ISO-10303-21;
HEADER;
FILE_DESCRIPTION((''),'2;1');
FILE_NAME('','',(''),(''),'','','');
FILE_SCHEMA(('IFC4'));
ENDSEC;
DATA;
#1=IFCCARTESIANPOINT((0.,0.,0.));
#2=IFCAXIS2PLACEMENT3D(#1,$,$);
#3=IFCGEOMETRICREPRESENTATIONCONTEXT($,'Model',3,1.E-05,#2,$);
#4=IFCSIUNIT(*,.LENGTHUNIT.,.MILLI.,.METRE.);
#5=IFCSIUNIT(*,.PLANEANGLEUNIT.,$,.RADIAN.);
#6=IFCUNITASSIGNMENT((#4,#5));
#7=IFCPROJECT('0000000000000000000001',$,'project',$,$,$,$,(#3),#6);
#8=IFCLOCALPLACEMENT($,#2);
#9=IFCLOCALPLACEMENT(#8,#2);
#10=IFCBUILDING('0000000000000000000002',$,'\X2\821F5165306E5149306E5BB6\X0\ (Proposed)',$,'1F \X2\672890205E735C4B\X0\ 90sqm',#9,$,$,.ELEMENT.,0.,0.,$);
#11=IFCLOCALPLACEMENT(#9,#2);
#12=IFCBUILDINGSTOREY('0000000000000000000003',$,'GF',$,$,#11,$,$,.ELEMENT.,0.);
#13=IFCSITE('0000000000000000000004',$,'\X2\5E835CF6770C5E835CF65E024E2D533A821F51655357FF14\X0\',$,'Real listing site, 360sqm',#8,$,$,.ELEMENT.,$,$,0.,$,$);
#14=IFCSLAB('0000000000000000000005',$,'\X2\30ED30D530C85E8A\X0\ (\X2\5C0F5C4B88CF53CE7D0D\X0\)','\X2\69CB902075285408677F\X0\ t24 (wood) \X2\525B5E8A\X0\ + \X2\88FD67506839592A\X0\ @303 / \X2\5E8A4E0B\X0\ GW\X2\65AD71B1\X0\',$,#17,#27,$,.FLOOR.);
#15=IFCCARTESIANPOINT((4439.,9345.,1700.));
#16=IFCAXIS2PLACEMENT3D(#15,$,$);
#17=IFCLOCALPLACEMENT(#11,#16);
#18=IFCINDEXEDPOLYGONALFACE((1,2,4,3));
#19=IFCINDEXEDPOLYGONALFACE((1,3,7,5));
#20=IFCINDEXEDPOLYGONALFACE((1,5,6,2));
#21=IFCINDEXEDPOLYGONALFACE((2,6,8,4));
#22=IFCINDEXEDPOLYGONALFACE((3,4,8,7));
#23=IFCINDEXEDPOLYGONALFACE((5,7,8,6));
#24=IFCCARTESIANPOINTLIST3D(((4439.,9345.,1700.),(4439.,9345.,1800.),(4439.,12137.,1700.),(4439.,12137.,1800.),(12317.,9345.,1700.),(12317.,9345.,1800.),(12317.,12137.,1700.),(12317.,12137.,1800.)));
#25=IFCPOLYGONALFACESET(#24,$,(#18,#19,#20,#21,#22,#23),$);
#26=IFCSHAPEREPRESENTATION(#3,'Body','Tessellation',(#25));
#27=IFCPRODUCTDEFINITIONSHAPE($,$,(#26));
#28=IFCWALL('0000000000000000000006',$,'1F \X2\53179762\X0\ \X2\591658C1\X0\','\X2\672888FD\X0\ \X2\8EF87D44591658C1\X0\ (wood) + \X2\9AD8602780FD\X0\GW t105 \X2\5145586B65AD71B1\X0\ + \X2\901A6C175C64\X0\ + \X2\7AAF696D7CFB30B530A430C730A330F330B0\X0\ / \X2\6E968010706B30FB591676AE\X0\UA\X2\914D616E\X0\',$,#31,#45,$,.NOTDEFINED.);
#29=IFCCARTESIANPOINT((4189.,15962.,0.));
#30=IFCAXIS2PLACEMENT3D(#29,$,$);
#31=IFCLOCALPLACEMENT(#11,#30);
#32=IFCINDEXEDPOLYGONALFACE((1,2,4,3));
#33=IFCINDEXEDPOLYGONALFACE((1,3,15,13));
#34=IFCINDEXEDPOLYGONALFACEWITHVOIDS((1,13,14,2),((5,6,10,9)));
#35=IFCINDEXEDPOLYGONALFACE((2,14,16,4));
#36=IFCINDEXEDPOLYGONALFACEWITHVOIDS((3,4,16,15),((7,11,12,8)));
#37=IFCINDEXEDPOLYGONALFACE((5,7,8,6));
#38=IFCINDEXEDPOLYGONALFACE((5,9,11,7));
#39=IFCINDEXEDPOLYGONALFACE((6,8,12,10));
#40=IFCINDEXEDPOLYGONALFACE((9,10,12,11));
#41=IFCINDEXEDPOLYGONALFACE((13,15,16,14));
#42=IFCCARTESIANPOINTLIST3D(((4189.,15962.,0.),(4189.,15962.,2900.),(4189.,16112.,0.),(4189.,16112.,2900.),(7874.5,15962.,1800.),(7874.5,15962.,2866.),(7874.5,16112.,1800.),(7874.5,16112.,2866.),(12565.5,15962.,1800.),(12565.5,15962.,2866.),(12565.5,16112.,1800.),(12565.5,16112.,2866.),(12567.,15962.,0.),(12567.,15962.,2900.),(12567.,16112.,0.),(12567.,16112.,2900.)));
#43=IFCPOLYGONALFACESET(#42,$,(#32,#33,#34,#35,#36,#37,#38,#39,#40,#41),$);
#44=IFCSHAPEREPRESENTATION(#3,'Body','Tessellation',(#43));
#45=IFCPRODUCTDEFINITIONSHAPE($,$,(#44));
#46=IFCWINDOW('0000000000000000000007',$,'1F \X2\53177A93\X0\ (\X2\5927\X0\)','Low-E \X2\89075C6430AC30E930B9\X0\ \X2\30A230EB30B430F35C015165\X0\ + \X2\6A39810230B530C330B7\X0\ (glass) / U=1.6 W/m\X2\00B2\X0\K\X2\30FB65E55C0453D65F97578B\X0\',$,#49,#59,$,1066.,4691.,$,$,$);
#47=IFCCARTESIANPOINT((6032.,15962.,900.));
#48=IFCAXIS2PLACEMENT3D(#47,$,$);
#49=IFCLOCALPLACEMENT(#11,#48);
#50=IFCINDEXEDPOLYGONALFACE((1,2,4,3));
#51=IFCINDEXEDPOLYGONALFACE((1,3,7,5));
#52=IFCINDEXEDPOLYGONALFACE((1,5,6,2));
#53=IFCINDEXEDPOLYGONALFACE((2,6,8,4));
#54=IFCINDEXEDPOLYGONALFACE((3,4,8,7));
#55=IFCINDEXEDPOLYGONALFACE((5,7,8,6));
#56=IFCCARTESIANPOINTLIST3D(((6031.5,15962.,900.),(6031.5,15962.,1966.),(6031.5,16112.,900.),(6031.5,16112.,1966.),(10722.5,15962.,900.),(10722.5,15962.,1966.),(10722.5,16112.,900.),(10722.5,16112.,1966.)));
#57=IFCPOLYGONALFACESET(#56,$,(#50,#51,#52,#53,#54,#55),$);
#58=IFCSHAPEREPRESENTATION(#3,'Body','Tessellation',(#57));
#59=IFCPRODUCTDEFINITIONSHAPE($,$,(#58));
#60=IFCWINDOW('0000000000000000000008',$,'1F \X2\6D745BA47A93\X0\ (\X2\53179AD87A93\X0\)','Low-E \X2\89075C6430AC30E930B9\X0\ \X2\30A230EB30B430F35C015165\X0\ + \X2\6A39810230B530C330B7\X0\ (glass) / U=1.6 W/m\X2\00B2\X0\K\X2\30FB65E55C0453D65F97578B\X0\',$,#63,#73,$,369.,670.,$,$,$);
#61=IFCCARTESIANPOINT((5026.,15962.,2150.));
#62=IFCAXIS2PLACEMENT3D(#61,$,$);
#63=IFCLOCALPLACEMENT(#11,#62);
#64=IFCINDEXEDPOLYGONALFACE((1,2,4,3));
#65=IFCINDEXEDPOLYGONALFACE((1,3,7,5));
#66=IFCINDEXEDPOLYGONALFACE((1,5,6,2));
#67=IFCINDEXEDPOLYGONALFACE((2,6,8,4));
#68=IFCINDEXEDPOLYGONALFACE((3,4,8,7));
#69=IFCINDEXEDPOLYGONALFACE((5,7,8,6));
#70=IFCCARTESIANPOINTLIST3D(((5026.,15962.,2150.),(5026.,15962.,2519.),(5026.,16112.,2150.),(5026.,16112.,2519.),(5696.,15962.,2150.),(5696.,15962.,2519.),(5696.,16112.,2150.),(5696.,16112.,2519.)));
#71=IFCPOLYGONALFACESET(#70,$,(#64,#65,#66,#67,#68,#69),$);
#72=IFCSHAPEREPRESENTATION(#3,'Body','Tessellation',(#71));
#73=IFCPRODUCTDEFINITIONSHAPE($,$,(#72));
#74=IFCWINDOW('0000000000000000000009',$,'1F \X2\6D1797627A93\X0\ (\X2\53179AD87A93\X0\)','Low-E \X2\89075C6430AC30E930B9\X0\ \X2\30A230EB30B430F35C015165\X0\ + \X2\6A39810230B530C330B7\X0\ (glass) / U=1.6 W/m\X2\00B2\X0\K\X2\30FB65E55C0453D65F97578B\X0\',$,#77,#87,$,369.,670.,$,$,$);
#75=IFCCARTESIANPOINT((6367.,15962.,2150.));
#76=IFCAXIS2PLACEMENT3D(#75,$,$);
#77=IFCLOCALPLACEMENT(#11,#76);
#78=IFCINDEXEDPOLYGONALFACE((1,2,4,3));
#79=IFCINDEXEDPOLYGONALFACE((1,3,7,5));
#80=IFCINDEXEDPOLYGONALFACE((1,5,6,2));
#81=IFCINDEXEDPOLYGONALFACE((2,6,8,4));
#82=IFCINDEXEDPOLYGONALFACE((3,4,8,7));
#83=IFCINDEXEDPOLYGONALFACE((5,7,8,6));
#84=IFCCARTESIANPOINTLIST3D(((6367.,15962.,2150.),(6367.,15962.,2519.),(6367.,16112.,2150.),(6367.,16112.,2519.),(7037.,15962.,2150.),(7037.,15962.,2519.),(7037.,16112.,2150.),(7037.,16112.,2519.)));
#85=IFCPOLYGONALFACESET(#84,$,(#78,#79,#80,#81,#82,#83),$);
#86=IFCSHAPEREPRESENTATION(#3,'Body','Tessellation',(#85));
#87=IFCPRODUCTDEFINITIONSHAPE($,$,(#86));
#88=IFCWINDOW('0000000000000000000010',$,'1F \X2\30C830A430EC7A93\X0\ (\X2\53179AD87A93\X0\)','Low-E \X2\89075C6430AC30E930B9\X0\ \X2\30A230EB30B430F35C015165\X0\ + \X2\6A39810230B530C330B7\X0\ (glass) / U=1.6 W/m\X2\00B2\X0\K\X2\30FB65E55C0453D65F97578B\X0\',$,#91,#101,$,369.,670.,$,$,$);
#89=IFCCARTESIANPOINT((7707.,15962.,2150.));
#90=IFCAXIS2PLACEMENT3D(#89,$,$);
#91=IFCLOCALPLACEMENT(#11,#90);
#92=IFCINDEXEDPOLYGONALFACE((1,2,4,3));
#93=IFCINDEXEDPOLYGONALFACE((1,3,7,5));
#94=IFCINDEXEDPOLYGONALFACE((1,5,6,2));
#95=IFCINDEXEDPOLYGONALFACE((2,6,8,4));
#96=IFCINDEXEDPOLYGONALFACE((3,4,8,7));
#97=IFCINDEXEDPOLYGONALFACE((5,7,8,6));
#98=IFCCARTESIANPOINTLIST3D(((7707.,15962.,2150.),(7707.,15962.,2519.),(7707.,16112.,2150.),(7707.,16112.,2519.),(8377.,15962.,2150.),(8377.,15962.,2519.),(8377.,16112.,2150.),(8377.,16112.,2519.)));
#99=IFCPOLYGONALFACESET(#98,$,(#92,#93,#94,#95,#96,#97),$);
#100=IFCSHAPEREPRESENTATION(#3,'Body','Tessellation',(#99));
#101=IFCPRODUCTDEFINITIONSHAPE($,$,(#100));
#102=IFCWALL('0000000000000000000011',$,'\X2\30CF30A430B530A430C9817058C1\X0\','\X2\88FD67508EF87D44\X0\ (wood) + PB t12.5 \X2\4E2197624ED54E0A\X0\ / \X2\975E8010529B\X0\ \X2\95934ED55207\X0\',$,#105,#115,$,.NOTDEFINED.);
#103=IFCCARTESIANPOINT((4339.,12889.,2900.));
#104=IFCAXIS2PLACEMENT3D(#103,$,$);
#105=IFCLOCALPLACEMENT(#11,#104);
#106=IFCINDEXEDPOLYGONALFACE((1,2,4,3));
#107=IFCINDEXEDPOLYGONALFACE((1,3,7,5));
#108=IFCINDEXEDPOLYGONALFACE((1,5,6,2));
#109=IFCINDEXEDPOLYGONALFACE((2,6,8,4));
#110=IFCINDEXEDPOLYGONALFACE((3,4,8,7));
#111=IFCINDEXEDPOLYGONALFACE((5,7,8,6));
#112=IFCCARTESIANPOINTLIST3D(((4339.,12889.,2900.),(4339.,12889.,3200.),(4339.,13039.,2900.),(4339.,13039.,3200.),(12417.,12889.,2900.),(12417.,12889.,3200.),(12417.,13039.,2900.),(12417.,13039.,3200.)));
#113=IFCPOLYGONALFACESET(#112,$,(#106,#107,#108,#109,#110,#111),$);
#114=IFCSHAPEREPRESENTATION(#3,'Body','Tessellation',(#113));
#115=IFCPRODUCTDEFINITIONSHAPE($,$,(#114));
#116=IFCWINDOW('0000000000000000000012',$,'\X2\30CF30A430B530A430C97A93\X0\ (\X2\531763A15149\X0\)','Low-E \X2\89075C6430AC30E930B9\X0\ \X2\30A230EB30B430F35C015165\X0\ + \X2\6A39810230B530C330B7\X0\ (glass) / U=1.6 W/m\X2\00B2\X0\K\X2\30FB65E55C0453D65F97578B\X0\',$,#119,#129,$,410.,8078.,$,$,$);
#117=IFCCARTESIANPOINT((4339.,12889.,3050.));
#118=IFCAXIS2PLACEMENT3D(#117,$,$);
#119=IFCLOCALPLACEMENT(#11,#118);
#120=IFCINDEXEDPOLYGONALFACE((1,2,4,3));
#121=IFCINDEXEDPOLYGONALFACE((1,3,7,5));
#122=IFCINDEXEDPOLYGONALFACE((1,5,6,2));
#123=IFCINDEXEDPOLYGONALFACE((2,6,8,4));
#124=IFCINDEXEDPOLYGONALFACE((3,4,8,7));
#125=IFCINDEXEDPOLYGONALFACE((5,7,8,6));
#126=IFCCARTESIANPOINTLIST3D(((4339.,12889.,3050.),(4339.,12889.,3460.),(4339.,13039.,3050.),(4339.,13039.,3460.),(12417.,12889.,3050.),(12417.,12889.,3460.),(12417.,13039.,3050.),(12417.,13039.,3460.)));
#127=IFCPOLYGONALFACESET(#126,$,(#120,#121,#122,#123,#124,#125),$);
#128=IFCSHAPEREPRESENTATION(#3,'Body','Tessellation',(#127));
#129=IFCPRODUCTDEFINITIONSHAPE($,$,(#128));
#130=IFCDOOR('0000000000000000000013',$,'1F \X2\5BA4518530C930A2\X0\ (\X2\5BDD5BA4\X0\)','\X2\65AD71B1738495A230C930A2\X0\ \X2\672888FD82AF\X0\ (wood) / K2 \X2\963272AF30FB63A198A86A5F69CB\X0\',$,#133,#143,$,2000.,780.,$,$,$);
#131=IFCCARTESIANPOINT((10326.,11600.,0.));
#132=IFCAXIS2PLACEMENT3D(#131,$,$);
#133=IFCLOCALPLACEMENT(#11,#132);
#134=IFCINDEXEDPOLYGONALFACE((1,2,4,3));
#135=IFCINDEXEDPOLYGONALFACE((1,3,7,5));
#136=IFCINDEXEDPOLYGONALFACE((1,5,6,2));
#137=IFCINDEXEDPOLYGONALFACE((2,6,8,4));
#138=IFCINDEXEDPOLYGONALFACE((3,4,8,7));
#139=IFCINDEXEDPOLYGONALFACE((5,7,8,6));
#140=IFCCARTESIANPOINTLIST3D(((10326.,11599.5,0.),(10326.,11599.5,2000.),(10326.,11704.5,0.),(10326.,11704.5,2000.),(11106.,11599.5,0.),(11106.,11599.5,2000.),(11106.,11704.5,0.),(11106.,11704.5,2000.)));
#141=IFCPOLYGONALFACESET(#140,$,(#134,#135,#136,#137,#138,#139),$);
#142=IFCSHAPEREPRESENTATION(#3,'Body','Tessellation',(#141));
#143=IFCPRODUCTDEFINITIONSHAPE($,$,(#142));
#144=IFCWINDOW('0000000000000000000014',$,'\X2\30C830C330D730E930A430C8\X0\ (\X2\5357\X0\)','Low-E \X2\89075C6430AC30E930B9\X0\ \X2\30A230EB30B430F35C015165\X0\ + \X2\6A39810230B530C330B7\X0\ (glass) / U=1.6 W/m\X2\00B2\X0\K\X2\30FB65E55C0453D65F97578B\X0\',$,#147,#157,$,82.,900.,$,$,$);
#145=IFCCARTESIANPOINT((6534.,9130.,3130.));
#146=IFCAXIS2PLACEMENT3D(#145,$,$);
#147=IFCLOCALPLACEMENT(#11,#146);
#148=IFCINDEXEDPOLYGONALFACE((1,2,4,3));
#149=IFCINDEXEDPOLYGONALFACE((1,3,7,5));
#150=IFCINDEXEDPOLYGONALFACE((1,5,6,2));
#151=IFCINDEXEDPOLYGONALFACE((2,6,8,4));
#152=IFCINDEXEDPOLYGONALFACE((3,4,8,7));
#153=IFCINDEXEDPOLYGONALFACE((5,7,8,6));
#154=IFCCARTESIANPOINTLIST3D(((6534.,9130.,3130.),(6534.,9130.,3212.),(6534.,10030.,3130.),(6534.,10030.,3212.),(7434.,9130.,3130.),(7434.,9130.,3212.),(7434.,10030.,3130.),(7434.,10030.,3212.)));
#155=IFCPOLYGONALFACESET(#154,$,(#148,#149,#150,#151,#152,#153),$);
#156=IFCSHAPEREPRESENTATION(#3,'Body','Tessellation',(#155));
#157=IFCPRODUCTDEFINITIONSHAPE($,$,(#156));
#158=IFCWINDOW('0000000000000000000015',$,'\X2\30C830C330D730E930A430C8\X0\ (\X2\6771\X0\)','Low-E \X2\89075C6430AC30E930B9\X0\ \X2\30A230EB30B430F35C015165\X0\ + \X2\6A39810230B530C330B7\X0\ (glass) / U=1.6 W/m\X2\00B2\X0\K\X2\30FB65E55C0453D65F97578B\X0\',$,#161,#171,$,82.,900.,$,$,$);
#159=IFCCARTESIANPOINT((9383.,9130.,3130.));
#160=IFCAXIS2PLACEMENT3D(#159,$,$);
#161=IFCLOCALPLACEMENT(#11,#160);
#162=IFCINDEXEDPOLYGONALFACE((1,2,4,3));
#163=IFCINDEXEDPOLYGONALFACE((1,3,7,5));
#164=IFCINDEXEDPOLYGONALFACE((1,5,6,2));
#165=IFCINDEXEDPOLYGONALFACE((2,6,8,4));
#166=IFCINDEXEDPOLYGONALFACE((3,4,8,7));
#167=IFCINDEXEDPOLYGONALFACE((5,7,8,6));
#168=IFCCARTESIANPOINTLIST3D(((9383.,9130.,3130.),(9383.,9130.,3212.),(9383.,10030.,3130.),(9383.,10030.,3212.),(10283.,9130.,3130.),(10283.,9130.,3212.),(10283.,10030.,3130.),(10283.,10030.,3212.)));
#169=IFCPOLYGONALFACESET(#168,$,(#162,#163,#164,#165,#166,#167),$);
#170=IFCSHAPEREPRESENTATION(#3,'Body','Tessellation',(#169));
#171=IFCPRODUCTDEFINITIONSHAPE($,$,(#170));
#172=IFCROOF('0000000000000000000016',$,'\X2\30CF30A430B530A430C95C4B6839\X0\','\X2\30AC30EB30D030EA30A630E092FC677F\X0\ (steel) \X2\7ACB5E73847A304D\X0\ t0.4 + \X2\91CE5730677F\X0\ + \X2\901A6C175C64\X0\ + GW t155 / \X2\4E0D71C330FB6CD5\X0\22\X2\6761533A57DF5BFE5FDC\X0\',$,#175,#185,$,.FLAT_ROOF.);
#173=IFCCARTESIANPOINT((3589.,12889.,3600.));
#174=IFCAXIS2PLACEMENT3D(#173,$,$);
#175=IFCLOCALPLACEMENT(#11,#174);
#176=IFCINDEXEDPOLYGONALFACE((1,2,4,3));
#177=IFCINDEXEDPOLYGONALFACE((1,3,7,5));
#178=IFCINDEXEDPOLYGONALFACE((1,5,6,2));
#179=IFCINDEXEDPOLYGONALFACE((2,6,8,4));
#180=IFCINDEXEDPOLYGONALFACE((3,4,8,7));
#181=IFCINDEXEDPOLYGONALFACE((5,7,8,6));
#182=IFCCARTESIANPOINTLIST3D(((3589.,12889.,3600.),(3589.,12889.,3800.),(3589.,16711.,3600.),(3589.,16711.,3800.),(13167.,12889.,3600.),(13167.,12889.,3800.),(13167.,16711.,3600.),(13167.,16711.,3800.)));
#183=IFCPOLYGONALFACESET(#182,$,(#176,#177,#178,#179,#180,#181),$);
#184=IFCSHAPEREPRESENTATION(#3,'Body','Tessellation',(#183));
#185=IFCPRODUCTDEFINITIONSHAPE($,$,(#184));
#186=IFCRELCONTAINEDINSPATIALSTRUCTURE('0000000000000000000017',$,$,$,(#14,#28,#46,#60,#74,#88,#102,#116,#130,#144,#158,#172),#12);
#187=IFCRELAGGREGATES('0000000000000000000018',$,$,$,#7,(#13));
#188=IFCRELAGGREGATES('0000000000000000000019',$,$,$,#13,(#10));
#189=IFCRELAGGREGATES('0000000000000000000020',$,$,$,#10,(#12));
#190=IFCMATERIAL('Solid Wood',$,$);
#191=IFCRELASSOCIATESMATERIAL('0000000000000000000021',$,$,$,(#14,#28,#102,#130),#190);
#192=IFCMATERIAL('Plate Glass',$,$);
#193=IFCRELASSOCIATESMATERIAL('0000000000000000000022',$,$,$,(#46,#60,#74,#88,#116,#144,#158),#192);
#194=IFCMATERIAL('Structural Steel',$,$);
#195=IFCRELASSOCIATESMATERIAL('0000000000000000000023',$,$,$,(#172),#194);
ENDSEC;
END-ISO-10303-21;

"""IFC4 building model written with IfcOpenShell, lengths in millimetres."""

from ifc_helpers import new_model, si_unit, frame, frame_2d, origin, place, context, project, spatial, rectangle, extrude, material, element, fill, save


model = new_model("IFC4")

# Units and contexts
model_context = context("Model", 3, precision=1e-05, world=origin())
ifc_project = project(units=[si_unit("LENGTHUNIT", "METRE", prefix="MILLI"), si_unit("PLANEANGLEUNIT", "RADIAN")], contexts=[model_context])

# Site, building, storey
site_placement = place(None, origin())
site = spatial("IfcSite", under=ifc_project, at=site_placement, Name="広島県広島市中区舟入南４", ObjectType="Real listing site, 360sqm", CompositionType="ELEMENT", RefElevation=0.0)
building_placement = place(site_placement, origin())
building = spatial("IfcBuilding", under=site, at=building_placement, Name="舟入の光の家 (Proposed)", ObjectType="1F 木造平屋 90sqm", CompositionType="ELEMENT", ElevationOfRefHeight=0.0, ElevationOfTerrain=0.0)
storey_placement = place(building_placement, origin())
storey = spatial("IfcBuildingStorey", under=building, at=storey_placement, Name="GF", CompositionType="ELEMENT", Elevation=0.0)

# Slab
ifc_material_1 = material(Name="Solid Wood")
slab_placement = place(storey_placement, frame((4439.0, 9345.0, 1700.0)))
element("IfcSlab", 1, at=slab_placement, inside=storey, material=ifc_material_1, Name="ロフト床 (小屋裏収納)", Description="構造用合板 t24 (wood) 剛床 + 製材根太 @303 / 床下 GW断熱", PredefinedType="FLOOR", context=model_context, shape_type="SweptSolid", body=[
    extrude(rectangle(XDim=7878.0, YDim=2792.0, at=frame_2d((3939.0, 1396.0))), frame((4439.0, 9345.0, 1700.0)), (0.0, 0.0, 1.0), 100.0),
])

# Wall, openings, windows
wall_1_placement = place(storey_placement, frame((4189.0, 15962.0, 0.0)))
wall_1 = element("IfcWall", 2, at=wall_1_placement, inside=storey, material=ifc_material_1, Name="1F 北面 外壁", Description="木製 軸組外壁 (wood) + 高性能GW t105 充填断熱 + 通気層 + 窯業系サイディング / 準耐火・外皮UA配慮", PredefinedType="NOTDEFINED", context=model_context, shape_type="SweptSolid", body=[
    extrude(rectangle(XDim=8378.0, YDim=150.0, at=frame_2d((4189.0, 75.0))), frame((4189.0, 15962.0, 0.0)), (0.0, 0.0, 1.0), 2900.0),
])
opening_1_placement = place(storey_placement, frame((6032.0, 15962.0, 900.0)))
opening_1 = element("IfcOpeningElement", 3, at=opening_1_placement, cuts=wall_1, PredefinedType="NOTDEFINED", context=model_context, shape_type="SweptSolid", body=[
    extrude(rectangle(XDim=4691.0, YDim=150.0, at=frame_2d((2345.0, 75.0))), frame((6032.0, 15962.0, 900.0)), (0.0, 0.0, 1.0), 1066.0),
])
opening_2_placement = place(storey_placement, frame((5026.0, 15962.0, 2150.0)))
opening_2 = element("IfcOpeningElement", 4, at=opening_2_placement, cuts=wall_1, PredefinedType="NOTDEFINED", context=model_context, shape_type="SweptSolid", body=[
    extrude(rectangle(XDim=670.0, YDim=150.0, at=frame_2d((335.0, 75.0))), frame((5026.0, 15962.0, 2150.0)), (0.0, 0.0, 1.0), 369.0),
])
opening_3_placement = place(storey_placement, frame((6367.0, 15962.0, 2150.0)))
opening_3 = element("IfcOpeningElement", 5, at=opening_3_placement, cuts=wall_1, PredefinedType="NOTDEFINED", context=model_context, shape_type="SweptSolid", body=[
    extrude(rectangle(XDim=670.0, YDim=150.0, at=frame_2d((335.0, 75.0))), frame((6367.0, 15962.0, 2150.0)), (0.0, 0.0, 1.0), 369.0),
])
opening_4_placement = place(storey_placement, frame((7707.0, 15962.0, 2150.0)))
opening_4 = element("IfcOpeningElement", 6, at=opening_4_placement, cuts=wall_1, PredefinedType="NOTDEFINED", context=model_context, shape_type="SweptSolid", body=[
    extrude(rectangle(XDim=670.0, YDim=150.0, at=frame_2d((335.0, 75.0))), frame((7707.0, 15962.0, 2150.0)), (0.0, 0.0, 1.0), 369.0),
])
ifc_material_2 = material(Name="Plate Glass")
window_1_placement = place(storey_placement, frame((6032.0, 15962.0, 900.0)))
window_1 = element("IfcWindow", 7, at=window_1_placement, inside=storey, material=ifc_material_2, Name="1F 北窓 (大)", Description="Low-E 複層ガラス アルゴン封入 + 樹脂サッシ (glass) / U=1.6 W/m²K・日射取得型", OverallHeight=1066.0, OverallWidth=4691.0, context=model_context, shape_type="SweptSolid", body=[
    extrude(rectangle(XDim=4691.0, YDim=150.0, at=frame_2d((2345.0, 75.0))), frame((6032.0, 15962.0, 900.0)), (0.0, 0.0, 1.0), 1066.0),
])
fill(opening_1, window_1)
window_2_placement = place(storey_placement, frame((5026.0, 15962.0, 2150.0)))
window_2 = element("IfcWindow", 8, at=window_2_placement, inside=storey, material=ifc_material_2, Name="1F 浴室窓 (北高窓)", Description="Low-E 複層ガラス アルゴン封入 + 樹脂サッシ (glass) / U=1.6 W/m²K・日射取得型", OverallHeight=369.0, OverallWidth=670.0, context=model_context, shape_type="SweptSolid", body=[
    extrude(rectangle(XDim=670.0, YDim=150.0, at=frame_2d((335.0, 75.0))), frame((5026.0, 15962.0, 2150.0)), (0.0, 0.0, 1.0), 369.0),
])
fill(opening_2, window_2)
window_3_placement = place(storey_placement, frame((6367.0, 15962.0, 2150.0)))
window_3 = element("IfcWindow", 9, at=window_3_placement, inside=storey, material=ifc_material_2, Name="1F 洗面窓 (北高窓)", Description="Low-E 複層ガラス アルゴン封入 + 樹脂サッシ (glass) / U=1.6 W/m²K・日射取得型", OverallHeight=369.0, OverallWidth=670.0, context=model_context, shape_type="SweptSolid", body=[
    extrude(rectangle(XDim=670.0, YDim=150.0, at=frame_2d((335.0, 75.0))), frame((6367.0, 15962.0, 2150.0)), (0.0, 0.0, 1.0), 369.0),
])
fill(opening_3, window_3)
window_4_placement = place(storey_placement, frame((7707.0, 15962.0, 2150.0)))
window_4 = element("IfcWindow", 10, at=window_4_placement, inside=storey, material=ifc_material_2, Name="1F トイレ窓 (北高窓)", Description="Low-E 複層ガラス アルゴン封入 + 樹脂サッシ (glass) / U=1.6 W/m²K・日射取得型", OverallHeight=369.0, OverallWidth=670.0, context=model_context, shape_type="SweptSolid", body=[
    extrude(rectangle(XDim=670.0, YDim=150.0, at=frame_2d((335.0, 75.0))), frame((7707.0, 15962.0, 2150.0)), (0.0, 0.0, 1.0), 369.0),
])
fill(opening_4, window_4)

# Wall, opening, window
wall_2_placement = place(storey_placement, frame((4339.0, 12889.0, 2900.0)))
wall_2 = element("IfcWall", 11, at=wall_2_placement, inside=storey, material=ifc_material_1, Name="ハイサイド腰壁", Description="製材軸組 (wood) + PB t12.5 両面仕上 / 非耐力 間仕切", PredefinedType="NOTDEFINED", context=model_context, shape_type="SweptSolid", body=[
    extrude(rectangle(XDim=8078.0, YDim=150.0, at=frame_2d((4039.0, 75.0))), frame((4339.0, 12889.0, 2900.0)), (0.0, 0.0, 1.0), 700.0),
])
opening_5_placement = place(storey_placement, frame((4339.0, 12889.0, 3050.0)))
opening_5 = element("IfcOpeningElement", 12, at=opening_5_placement, cuts=wall_2, PredefinedType="NOTDEFINED", context=model_context, shape_type="SweptSolid", body=[
    extrude(rectangle(XDim=8078.0, YDim=150.0, at=frame_2d((4039.0, 75.0))), frame((4339.0, 12889.0, 3050.0)), (0.0, 0.0, 1.0), 410.0),
])
window_5_placement = place(storey_placement, frame((4339.0, 12889.0, 3050.0)))
window_5 = element("IfcWindow", 13, at=window_5_placement, inside=storey, material=ifc_material_2, Name="ハイサイド窓 (北採光)", Description="Low-E 複層ガラス アルゴン封入 + 樹脂サッシ (glass) / U=1.6 W/m²K・日射取得型", OverallHeight=410.0, OverallWidth=8078.0, context=model_context, shape_type="SweptSolid", body=[
    extrude(rectangle(XDim=8078.0, YDim=150.0, at=frame_2d((4039.0, 75.0))), frame((4339.0, 12889.0, 3050.0)), (0.0, 0.0, 1.0), 410.0),
])
fill(opening_5, window_5)

# Door
door_1_placement = place(storey_placement, frame((10326.0, 11600.0, 0.0)))
element("IfcDoor", 14, at=door_1_placement, inside=storey, material=ifc_material_1, Name="1F 室内ドア (寝室)", Description="断熱玄関ドア 木製芯 (wood) / K2 防犯・採風機構", OverallHeight=2000.0, OverallWidth=780.0, context=model_context, shape_type="SweptSolid", body=[
    extrude(rectangle(XDim=780.0, YDim=105.0, at=frame_2d((390.0, 52.0))), frame((10326.0, 11600.0, 0.0)), (0.0, 0.0, 1.0), 2000.0),
])

# Windows
window_6_placement = place(storey_placement, frame((6534.0, 9130.0, 3130.0)))
element("IfcWindow", 15, at=window_6_placement, inside=storey, material=ifc_material_2, Name="トップライト (南)", Description="Low-E 複層ガラス アルゴン封入 + 樹脂サッシ (glass) / U=1.6 W/m²K・日射取得型", OverallHeight=82.0, OverallWidth=900.0, context=model_context, shape_type="SweptSolid", body=[
    extrude(rectangle(XDim=900.0, YDim=900.0, at=frame_2d((450.0, 450.0))), frame((6534.0, 9130.0, 3130.0)), (0.0, 0.0, 1.0), 82.0),
])
window_7_placement = place(storey_placement, frame((9383.0, 9130.0, 3130.0)))
element("IfcWindow", 16, at=window_7_placement, inside=storey, material=ifc_material_2, Name="トップライト (東)", Description="Low-E 複層ガラス アルゴン封入 + 樹脂サッシ (glass) / U=1.6 W/m²K・日射取得型", OverallHeight=82.0, OverallWidth=900.0, context=model_context, shape_type="SweptSolid", body=[
    extrude(rectangle(XDim=900.0, YDim=900.0, at=frame_2d((450.0, 450.0))), frame((9383.0, 9130.0, 3130.0)), (0.0, 0.0, 1.0), 82.0),
])

# Roof
ifc_material_3 = material(Name="Structural Steel")
roof_placement = place(storey_placement, frame((3589.0, 12889.0, 3600.0)))
element("IfcRoof", 17, at=roof_placement, inside=storey, material=ifc_material_3, Name="ハイサイド屋根", Description="ガルバリウム鋼板 (steel) 立平葺き t0.4 + 野地板 + 通気層 + GW t155 / 不燃・法22条区域対応", PredefinedType="FLAT_ROOF", context=model_context, shape_type="SweptSolid", body=[
    extrude(rectangle(XDim=9578.0, YDim=3822.0, at=frame_2d((4789.0, 1911.0))), frame((3589.0, 12889.0, 3600.0)), (0.0, 0.0, 1.0), 200.0),
])

save(model, "model.ifc")
